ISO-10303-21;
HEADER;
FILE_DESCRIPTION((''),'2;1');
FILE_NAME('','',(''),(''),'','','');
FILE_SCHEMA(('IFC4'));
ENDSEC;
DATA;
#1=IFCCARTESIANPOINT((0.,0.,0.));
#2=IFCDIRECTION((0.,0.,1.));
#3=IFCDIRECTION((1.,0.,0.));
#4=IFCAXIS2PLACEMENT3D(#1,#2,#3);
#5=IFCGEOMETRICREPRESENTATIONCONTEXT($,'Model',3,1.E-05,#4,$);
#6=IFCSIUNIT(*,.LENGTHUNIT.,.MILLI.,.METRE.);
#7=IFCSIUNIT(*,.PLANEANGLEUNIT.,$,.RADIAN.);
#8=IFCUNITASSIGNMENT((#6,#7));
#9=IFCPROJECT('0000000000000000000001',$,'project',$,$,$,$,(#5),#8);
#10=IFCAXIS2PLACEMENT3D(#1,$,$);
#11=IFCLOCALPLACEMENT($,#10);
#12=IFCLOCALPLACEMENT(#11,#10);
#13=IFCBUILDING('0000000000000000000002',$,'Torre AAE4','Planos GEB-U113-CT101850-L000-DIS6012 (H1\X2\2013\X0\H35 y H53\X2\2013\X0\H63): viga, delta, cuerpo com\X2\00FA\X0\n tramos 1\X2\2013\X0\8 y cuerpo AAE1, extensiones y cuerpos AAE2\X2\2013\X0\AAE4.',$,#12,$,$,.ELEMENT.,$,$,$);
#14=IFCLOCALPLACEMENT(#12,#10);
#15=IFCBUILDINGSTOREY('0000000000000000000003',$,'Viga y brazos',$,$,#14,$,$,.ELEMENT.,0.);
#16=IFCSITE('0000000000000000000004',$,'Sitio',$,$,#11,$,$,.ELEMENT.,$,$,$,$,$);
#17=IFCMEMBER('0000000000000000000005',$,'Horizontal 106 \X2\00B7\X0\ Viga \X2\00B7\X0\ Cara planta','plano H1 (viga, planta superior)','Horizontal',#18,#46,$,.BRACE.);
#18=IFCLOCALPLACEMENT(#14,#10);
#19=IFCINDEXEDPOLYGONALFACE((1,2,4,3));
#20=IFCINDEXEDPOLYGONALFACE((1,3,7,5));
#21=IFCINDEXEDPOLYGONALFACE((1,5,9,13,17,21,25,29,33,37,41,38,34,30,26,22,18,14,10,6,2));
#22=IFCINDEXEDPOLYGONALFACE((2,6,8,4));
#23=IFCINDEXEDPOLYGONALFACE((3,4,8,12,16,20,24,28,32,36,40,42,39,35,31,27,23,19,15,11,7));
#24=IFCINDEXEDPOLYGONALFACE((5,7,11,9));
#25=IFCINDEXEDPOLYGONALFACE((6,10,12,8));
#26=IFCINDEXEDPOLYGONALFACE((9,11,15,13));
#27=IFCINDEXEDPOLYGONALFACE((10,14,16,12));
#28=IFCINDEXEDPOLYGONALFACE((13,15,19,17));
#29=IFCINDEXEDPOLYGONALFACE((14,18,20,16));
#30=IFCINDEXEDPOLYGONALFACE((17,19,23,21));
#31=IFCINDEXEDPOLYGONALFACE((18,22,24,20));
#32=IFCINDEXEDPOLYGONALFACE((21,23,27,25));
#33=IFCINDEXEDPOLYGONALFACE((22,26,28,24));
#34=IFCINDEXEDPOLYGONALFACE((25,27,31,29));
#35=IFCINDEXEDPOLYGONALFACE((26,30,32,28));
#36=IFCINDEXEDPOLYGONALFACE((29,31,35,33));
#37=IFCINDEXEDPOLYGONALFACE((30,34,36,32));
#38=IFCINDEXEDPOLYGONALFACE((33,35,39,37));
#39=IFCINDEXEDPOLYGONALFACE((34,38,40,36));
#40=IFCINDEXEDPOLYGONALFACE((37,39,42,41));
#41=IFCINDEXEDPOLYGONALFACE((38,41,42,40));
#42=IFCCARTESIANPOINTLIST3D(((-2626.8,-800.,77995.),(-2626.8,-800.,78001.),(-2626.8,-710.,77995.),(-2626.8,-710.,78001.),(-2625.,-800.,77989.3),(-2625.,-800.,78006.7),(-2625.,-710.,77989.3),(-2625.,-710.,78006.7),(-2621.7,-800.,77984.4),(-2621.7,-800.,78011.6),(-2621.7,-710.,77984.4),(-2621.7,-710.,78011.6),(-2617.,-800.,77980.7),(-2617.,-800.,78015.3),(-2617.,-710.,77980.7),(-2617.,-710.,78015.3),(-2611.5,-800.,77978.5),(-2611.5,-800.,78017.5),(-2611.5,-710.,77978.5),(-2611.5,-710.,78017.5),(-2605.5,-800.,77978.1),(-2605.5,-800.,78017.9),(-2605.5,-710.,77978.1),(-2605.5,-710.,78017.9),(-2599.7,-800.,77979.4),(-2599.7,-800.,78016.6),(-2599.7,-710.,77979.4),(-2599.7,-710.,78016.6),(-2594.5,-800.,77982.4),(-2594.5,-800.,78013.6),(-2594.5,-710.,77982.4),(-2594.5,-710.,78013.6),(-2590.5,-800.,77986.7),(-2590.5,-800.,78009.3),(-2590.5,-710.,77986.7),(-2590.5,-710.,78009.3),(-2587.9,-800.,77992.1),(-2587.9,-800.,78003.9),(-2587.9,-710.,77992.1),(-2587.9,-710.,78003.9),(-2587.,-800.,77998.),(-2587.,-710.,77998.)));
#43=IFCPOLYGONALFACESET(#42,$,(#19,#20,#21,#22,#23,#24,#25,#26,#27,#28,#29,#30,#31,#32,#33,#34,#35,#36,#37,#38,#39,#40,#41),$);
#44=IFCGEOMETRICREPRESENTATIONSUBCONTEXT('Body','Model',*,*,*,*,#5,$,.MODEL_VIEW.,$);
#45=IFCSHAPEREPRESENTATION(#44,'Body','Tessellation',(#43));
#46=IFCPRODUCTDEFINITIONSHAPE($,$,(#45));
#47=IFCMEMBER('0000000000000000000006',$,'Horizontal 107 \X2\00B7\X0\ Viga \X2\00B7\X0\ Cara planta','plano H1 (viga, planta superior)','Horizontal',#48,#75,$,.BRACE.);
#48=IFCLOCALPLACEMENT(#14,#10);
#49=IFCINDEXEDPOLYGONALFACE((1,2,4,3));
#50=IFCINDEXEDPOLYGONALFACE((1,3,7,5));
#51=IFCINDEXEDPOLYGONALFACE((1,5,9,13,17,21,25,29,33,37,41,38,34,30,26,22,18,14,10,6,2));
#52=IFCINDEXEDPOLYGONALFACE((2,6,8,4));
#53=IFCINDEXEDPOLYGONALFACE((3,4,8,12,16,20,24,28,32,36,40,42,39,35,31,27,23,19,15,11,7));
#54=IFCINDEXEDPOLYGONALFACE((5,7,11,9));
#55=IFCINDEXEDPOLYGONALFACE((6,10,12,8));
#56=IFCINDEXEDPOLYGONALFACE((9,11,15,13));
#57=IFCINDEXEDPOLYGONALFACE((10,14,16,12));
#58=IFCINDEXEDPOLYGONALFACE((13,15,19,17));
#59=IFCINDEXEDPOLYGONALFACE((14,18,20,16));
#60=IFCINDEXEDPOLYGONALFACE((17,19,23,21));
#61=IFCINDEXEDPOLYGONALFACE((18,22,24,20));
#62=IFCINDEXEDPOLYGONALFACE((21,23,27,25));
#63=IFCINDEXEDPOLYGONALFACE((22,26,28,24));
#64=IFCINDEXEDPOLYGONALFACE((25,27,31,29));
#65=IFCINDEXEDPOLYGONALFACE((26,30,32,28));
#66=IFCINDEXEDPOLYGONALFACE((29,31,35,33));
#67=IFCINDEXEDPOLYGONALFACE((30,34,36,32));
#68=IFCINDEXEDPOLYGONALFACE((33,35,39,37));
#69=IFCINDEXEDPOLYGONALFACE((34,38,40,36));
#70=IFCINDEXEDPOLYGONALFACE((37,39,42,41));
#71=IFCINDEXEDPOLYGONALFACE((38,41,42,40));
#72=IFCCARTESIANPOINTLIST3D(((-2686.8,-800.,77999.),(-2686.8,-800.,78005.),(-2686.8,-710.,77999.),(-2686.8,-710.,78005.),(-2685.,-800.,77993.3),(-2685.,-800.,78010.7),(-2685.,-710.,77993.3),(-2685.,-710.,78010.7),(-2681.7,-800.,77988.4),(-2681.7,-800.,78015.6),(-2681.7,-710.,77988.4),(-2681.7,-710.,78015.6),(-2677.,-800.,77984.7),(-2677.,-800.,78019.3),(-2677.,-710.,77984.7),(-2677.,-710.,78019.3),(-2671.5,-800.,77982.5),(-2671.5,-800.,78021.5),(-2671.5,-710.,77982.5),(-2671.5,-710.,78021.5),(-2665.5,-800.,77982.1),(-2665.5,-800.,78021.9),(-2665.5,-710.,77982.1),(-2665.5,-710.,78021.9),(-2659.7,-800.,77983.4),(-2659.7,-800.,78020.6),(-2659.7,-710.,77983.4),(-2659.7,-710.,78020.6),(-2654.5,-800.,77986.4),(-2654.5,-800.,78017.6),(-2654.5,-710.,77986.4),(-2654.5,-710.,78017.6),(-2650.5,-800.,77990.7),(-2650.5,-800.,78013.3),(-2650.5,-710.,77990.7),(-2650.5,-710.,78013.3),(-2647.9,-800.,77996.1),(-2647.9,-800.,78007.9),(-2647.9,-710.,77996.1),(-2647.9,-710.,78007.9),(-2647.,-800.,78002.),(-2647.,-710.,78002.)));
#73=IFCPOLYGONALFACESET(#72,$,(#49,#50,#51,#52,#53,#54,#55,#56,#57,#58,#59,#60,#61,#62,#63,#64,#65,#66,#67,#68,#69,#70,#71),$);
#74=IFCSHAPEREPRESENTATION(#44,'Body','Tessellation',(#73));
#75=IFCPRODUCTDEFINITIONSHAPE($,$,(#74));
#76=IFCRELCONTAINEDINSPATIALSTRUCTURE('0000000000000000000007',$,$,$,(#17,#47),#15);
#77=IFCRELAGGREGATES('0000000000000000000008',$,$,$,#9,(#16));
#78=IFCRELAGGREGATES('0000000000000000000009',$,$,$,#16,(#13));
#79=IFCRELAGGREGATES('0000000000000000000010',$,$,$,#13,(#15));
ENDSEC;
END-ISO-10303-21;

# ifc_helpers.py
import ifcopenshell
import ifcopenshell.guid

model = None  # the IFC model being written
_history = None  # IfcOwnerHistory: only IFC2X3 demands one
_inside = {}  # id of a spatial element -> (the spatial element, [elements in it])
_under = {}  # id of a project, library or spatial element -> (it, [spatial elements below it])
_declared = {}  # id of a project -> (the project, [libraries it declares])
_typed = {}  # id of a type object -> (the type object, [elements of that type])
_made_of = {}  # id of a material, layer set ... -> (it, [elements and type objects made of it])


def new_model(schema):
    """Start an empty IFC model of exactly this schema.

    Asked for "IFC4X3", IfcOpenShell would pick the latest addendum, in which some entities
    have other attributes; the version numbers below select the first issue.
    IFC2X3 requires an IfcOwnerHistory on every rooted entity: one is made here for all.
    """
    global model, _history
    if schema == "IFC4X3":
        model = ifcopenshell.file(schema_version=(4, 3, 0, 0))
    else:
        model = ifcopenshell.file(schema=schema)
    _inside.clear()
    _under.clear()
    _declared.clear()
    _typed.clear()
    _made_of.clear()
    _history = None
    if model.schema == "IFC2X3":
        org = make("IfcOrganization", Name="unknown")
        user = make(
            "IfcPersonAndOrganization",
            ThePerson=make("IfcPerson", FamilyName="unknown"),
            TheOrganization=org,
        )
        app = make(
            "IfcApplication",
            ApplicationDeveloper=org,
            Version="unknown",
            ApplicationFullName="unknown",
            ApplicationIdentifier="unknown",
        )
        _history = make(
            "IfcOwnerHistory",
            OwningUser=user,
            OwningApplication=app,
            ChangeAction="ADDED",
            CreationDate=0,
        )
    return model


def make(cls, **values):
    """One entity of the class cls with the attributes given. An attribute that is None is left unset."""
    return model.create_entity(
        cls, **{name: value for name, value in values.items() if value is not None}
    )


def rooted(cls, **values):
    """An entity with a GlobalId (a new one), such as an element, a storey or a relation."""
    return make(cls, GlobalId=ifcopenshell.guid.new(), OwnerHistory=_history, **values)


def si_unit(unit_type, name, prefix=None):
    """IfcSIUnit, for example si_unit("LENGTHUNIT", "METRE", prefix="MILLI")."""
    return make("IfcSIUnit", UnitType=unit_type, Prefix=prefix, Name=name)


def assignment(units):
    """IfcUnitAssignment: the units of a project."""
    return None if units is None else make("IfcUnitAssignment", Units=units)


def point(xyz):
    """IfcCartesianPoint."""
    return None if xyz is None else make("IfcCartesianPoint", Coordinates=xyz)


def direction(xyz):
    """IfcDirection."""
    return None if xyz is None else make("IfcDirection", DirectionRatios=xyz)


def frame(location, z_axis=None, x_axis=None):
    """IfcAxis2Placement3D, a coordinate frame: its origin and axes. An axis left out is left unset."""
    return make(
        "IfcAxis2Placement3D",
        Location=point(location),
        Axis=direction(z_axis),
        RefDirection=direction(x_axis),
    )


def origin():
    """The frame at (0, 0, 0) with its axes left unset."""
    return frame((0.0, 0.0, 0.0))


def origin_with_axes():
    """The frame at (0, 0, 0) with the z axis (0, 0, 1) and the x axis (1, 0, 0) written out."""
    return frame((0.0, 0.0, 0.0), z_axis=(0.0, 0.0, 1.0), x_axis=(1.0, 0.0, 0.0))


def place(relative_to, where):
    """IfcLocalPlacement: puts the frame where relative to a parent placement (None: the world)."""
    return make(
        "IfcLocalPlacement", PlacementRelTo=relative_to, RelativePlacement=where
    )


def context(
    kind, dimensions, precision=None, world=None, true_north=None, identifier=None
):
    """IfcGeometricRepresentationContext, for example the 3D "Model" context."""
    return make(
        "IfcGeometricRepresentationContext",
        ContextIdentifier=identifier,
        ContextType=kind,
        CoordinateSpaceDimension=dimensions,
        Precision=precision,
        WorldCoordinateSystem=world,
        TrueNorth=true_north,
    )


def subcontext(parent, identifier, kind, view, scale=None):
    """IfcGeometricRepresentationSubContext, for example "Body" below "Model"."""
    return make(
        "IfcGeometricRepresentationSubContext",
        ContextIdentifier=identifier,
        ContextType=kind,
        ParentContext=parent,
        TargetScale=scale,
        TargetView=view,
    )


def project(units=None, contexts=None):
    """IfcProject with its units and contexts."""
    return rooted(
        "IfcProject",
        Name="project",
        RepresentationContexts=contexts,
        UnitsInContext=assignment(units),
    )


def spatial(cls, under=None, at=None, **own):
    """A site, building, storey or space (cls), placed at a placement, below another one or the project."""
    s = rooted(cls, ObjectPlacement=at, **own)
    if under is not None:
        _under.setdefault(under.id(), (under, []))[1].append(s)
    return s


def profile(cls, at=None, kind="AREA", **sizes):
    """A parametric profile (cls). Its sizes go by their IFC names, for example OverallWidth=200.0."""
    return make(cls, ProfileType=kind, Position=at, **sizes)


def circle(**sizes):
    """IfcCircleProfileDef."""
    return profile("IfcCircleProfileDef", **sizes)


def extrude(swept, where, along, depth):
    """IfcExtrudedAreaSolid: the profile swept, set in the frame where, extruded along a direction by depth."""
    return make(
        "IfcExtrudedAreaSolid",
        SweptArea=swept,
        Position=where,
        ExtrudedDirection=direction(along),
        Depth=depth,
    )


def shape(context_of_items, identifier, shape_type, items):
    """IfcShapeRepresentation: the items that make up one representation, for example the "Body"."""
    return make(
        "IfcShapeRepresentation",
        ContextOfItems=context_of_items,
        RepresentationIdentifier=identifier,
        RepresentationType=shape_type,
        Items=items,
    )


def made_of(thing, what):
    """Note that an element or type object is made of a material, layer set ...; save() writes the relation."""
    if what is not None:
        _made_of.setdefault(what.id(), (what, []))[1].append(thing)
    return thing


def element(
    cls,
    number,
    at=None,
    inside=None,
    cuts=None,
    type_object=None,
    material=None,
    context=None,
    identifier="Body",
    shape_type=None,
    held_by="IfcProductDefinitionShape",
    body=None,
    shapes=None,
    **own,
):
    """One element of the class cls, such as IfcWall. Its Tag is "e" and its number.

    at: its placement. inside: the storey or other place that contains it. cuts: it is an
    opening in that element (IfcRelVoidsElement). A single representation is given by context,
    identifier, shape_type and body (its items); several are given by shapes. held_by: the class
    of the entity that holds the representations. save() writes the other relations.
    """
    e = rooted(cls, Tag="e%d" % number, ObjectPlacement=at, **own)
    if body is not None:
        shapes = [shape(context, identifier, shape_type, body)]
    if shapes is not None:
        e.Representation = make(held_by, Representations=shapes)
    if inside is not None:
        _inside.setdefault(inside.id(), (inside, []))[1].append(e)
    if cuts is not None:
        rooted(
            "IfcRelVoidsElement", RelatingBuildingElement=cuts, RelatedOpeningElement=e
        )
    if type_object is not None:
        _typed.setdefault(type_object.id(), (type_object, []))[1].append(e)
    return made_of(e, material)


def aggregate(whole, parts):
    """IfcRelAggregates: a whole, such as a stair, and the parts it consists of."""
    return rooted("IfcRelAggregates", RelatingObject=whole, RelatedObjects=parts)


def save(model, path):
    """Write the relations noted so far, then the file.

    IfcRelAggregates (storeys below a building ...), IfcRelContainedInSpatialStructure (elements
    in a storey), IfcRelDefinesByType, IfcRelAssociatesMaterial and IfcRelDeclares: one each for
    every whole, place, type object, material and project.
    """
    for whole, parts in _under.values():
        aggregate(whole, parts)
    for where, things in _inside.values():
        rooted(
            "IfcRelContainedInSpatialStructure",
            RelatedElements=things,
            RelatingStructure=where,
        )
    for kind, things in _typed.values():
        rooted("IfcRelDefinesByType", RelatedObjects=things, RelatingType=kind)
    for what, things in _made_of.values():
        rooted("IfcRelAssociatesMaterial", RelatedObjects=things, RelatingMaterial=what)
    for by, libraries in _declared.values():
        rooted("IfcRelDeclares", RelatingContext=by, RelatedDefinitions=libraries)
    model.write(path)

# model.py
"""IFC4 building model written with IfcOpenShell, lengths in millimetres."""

from ifc_helpers import new_model, si_unit, frame, origin, origin_with_axes, place, context, subcontext, project, spatial, circle, extrude, element, save


model = new_model("IFC4")

# Units and contexts
model_context = context("Model", 3, precision=1e-05, world=origin_with_axes())
body_context = subcontext(model_context, "Body", "Model", "MODEL_VIEW")
ifc_project = project(units=[si_unit("LENGTHUNIT", "METRE", prefix="MILLI"), si_unit("PLANEANGLEUNIT", "RADIAN")], contexts=[model_context])

# Site, building, storey
site_placement = place(None, origin())
site = spatial("IfcSite", under=ifc_project, at=site_placement, Name="Sitio", CompositionType="ELEMENT")
building_placement = place(site_placement, origin())
building = spatial("IfcBuilding", under=site, at=building_placement, Name="Torre AAE4", Description="Planos GEB-U113-CT101850-L000-DIS6012 (H1–H35 y H53–H63): viga, delta, cuerpo común tramos 1–8 y cuerpo AAE1, extensiones y cuerpos AAE2–AAE4.", CompositionType="ELEMENT")
storey_placement = place(building_placement, origin())
storey = spatial("IfcBuildingStorey", under=building, at=storey_placement, Name="Viga y brazos", CompositionType="ELEMENT", Elevation=0.0)

# Members
for number, where, z_axis, x_axis, name in (
    (1, (-2607.0, -710.0, 77998.0), (0.0, -1.0, 0.0), (1.0, 0.0, 0.0), "Horizontal 106 · Viga · Cara planta"),
    (2, (-2667.0, -710.0, 78002.0), (0.0, -1.0, 0.0), (1.0, 0.0, 0.0), "Horizontal 107 · Viga · Cara planta"),
):
    element("IfcMember", number, at=place(storey_placement, frame(where, z_axis=z_axis, x_axis=x_axis)), inside=storey, Name=name, Description="plano H1 (viga, planta superior)", ObjectType="Horizontal", PredefinedType="BRACE", context=body_context, shape_type="SweptSolid", body=[
        extrude(circle(Radius=20.0), None, (0.0, 0.0, 1.0), 90.0),
    ])

save(model, "model.ifc")
